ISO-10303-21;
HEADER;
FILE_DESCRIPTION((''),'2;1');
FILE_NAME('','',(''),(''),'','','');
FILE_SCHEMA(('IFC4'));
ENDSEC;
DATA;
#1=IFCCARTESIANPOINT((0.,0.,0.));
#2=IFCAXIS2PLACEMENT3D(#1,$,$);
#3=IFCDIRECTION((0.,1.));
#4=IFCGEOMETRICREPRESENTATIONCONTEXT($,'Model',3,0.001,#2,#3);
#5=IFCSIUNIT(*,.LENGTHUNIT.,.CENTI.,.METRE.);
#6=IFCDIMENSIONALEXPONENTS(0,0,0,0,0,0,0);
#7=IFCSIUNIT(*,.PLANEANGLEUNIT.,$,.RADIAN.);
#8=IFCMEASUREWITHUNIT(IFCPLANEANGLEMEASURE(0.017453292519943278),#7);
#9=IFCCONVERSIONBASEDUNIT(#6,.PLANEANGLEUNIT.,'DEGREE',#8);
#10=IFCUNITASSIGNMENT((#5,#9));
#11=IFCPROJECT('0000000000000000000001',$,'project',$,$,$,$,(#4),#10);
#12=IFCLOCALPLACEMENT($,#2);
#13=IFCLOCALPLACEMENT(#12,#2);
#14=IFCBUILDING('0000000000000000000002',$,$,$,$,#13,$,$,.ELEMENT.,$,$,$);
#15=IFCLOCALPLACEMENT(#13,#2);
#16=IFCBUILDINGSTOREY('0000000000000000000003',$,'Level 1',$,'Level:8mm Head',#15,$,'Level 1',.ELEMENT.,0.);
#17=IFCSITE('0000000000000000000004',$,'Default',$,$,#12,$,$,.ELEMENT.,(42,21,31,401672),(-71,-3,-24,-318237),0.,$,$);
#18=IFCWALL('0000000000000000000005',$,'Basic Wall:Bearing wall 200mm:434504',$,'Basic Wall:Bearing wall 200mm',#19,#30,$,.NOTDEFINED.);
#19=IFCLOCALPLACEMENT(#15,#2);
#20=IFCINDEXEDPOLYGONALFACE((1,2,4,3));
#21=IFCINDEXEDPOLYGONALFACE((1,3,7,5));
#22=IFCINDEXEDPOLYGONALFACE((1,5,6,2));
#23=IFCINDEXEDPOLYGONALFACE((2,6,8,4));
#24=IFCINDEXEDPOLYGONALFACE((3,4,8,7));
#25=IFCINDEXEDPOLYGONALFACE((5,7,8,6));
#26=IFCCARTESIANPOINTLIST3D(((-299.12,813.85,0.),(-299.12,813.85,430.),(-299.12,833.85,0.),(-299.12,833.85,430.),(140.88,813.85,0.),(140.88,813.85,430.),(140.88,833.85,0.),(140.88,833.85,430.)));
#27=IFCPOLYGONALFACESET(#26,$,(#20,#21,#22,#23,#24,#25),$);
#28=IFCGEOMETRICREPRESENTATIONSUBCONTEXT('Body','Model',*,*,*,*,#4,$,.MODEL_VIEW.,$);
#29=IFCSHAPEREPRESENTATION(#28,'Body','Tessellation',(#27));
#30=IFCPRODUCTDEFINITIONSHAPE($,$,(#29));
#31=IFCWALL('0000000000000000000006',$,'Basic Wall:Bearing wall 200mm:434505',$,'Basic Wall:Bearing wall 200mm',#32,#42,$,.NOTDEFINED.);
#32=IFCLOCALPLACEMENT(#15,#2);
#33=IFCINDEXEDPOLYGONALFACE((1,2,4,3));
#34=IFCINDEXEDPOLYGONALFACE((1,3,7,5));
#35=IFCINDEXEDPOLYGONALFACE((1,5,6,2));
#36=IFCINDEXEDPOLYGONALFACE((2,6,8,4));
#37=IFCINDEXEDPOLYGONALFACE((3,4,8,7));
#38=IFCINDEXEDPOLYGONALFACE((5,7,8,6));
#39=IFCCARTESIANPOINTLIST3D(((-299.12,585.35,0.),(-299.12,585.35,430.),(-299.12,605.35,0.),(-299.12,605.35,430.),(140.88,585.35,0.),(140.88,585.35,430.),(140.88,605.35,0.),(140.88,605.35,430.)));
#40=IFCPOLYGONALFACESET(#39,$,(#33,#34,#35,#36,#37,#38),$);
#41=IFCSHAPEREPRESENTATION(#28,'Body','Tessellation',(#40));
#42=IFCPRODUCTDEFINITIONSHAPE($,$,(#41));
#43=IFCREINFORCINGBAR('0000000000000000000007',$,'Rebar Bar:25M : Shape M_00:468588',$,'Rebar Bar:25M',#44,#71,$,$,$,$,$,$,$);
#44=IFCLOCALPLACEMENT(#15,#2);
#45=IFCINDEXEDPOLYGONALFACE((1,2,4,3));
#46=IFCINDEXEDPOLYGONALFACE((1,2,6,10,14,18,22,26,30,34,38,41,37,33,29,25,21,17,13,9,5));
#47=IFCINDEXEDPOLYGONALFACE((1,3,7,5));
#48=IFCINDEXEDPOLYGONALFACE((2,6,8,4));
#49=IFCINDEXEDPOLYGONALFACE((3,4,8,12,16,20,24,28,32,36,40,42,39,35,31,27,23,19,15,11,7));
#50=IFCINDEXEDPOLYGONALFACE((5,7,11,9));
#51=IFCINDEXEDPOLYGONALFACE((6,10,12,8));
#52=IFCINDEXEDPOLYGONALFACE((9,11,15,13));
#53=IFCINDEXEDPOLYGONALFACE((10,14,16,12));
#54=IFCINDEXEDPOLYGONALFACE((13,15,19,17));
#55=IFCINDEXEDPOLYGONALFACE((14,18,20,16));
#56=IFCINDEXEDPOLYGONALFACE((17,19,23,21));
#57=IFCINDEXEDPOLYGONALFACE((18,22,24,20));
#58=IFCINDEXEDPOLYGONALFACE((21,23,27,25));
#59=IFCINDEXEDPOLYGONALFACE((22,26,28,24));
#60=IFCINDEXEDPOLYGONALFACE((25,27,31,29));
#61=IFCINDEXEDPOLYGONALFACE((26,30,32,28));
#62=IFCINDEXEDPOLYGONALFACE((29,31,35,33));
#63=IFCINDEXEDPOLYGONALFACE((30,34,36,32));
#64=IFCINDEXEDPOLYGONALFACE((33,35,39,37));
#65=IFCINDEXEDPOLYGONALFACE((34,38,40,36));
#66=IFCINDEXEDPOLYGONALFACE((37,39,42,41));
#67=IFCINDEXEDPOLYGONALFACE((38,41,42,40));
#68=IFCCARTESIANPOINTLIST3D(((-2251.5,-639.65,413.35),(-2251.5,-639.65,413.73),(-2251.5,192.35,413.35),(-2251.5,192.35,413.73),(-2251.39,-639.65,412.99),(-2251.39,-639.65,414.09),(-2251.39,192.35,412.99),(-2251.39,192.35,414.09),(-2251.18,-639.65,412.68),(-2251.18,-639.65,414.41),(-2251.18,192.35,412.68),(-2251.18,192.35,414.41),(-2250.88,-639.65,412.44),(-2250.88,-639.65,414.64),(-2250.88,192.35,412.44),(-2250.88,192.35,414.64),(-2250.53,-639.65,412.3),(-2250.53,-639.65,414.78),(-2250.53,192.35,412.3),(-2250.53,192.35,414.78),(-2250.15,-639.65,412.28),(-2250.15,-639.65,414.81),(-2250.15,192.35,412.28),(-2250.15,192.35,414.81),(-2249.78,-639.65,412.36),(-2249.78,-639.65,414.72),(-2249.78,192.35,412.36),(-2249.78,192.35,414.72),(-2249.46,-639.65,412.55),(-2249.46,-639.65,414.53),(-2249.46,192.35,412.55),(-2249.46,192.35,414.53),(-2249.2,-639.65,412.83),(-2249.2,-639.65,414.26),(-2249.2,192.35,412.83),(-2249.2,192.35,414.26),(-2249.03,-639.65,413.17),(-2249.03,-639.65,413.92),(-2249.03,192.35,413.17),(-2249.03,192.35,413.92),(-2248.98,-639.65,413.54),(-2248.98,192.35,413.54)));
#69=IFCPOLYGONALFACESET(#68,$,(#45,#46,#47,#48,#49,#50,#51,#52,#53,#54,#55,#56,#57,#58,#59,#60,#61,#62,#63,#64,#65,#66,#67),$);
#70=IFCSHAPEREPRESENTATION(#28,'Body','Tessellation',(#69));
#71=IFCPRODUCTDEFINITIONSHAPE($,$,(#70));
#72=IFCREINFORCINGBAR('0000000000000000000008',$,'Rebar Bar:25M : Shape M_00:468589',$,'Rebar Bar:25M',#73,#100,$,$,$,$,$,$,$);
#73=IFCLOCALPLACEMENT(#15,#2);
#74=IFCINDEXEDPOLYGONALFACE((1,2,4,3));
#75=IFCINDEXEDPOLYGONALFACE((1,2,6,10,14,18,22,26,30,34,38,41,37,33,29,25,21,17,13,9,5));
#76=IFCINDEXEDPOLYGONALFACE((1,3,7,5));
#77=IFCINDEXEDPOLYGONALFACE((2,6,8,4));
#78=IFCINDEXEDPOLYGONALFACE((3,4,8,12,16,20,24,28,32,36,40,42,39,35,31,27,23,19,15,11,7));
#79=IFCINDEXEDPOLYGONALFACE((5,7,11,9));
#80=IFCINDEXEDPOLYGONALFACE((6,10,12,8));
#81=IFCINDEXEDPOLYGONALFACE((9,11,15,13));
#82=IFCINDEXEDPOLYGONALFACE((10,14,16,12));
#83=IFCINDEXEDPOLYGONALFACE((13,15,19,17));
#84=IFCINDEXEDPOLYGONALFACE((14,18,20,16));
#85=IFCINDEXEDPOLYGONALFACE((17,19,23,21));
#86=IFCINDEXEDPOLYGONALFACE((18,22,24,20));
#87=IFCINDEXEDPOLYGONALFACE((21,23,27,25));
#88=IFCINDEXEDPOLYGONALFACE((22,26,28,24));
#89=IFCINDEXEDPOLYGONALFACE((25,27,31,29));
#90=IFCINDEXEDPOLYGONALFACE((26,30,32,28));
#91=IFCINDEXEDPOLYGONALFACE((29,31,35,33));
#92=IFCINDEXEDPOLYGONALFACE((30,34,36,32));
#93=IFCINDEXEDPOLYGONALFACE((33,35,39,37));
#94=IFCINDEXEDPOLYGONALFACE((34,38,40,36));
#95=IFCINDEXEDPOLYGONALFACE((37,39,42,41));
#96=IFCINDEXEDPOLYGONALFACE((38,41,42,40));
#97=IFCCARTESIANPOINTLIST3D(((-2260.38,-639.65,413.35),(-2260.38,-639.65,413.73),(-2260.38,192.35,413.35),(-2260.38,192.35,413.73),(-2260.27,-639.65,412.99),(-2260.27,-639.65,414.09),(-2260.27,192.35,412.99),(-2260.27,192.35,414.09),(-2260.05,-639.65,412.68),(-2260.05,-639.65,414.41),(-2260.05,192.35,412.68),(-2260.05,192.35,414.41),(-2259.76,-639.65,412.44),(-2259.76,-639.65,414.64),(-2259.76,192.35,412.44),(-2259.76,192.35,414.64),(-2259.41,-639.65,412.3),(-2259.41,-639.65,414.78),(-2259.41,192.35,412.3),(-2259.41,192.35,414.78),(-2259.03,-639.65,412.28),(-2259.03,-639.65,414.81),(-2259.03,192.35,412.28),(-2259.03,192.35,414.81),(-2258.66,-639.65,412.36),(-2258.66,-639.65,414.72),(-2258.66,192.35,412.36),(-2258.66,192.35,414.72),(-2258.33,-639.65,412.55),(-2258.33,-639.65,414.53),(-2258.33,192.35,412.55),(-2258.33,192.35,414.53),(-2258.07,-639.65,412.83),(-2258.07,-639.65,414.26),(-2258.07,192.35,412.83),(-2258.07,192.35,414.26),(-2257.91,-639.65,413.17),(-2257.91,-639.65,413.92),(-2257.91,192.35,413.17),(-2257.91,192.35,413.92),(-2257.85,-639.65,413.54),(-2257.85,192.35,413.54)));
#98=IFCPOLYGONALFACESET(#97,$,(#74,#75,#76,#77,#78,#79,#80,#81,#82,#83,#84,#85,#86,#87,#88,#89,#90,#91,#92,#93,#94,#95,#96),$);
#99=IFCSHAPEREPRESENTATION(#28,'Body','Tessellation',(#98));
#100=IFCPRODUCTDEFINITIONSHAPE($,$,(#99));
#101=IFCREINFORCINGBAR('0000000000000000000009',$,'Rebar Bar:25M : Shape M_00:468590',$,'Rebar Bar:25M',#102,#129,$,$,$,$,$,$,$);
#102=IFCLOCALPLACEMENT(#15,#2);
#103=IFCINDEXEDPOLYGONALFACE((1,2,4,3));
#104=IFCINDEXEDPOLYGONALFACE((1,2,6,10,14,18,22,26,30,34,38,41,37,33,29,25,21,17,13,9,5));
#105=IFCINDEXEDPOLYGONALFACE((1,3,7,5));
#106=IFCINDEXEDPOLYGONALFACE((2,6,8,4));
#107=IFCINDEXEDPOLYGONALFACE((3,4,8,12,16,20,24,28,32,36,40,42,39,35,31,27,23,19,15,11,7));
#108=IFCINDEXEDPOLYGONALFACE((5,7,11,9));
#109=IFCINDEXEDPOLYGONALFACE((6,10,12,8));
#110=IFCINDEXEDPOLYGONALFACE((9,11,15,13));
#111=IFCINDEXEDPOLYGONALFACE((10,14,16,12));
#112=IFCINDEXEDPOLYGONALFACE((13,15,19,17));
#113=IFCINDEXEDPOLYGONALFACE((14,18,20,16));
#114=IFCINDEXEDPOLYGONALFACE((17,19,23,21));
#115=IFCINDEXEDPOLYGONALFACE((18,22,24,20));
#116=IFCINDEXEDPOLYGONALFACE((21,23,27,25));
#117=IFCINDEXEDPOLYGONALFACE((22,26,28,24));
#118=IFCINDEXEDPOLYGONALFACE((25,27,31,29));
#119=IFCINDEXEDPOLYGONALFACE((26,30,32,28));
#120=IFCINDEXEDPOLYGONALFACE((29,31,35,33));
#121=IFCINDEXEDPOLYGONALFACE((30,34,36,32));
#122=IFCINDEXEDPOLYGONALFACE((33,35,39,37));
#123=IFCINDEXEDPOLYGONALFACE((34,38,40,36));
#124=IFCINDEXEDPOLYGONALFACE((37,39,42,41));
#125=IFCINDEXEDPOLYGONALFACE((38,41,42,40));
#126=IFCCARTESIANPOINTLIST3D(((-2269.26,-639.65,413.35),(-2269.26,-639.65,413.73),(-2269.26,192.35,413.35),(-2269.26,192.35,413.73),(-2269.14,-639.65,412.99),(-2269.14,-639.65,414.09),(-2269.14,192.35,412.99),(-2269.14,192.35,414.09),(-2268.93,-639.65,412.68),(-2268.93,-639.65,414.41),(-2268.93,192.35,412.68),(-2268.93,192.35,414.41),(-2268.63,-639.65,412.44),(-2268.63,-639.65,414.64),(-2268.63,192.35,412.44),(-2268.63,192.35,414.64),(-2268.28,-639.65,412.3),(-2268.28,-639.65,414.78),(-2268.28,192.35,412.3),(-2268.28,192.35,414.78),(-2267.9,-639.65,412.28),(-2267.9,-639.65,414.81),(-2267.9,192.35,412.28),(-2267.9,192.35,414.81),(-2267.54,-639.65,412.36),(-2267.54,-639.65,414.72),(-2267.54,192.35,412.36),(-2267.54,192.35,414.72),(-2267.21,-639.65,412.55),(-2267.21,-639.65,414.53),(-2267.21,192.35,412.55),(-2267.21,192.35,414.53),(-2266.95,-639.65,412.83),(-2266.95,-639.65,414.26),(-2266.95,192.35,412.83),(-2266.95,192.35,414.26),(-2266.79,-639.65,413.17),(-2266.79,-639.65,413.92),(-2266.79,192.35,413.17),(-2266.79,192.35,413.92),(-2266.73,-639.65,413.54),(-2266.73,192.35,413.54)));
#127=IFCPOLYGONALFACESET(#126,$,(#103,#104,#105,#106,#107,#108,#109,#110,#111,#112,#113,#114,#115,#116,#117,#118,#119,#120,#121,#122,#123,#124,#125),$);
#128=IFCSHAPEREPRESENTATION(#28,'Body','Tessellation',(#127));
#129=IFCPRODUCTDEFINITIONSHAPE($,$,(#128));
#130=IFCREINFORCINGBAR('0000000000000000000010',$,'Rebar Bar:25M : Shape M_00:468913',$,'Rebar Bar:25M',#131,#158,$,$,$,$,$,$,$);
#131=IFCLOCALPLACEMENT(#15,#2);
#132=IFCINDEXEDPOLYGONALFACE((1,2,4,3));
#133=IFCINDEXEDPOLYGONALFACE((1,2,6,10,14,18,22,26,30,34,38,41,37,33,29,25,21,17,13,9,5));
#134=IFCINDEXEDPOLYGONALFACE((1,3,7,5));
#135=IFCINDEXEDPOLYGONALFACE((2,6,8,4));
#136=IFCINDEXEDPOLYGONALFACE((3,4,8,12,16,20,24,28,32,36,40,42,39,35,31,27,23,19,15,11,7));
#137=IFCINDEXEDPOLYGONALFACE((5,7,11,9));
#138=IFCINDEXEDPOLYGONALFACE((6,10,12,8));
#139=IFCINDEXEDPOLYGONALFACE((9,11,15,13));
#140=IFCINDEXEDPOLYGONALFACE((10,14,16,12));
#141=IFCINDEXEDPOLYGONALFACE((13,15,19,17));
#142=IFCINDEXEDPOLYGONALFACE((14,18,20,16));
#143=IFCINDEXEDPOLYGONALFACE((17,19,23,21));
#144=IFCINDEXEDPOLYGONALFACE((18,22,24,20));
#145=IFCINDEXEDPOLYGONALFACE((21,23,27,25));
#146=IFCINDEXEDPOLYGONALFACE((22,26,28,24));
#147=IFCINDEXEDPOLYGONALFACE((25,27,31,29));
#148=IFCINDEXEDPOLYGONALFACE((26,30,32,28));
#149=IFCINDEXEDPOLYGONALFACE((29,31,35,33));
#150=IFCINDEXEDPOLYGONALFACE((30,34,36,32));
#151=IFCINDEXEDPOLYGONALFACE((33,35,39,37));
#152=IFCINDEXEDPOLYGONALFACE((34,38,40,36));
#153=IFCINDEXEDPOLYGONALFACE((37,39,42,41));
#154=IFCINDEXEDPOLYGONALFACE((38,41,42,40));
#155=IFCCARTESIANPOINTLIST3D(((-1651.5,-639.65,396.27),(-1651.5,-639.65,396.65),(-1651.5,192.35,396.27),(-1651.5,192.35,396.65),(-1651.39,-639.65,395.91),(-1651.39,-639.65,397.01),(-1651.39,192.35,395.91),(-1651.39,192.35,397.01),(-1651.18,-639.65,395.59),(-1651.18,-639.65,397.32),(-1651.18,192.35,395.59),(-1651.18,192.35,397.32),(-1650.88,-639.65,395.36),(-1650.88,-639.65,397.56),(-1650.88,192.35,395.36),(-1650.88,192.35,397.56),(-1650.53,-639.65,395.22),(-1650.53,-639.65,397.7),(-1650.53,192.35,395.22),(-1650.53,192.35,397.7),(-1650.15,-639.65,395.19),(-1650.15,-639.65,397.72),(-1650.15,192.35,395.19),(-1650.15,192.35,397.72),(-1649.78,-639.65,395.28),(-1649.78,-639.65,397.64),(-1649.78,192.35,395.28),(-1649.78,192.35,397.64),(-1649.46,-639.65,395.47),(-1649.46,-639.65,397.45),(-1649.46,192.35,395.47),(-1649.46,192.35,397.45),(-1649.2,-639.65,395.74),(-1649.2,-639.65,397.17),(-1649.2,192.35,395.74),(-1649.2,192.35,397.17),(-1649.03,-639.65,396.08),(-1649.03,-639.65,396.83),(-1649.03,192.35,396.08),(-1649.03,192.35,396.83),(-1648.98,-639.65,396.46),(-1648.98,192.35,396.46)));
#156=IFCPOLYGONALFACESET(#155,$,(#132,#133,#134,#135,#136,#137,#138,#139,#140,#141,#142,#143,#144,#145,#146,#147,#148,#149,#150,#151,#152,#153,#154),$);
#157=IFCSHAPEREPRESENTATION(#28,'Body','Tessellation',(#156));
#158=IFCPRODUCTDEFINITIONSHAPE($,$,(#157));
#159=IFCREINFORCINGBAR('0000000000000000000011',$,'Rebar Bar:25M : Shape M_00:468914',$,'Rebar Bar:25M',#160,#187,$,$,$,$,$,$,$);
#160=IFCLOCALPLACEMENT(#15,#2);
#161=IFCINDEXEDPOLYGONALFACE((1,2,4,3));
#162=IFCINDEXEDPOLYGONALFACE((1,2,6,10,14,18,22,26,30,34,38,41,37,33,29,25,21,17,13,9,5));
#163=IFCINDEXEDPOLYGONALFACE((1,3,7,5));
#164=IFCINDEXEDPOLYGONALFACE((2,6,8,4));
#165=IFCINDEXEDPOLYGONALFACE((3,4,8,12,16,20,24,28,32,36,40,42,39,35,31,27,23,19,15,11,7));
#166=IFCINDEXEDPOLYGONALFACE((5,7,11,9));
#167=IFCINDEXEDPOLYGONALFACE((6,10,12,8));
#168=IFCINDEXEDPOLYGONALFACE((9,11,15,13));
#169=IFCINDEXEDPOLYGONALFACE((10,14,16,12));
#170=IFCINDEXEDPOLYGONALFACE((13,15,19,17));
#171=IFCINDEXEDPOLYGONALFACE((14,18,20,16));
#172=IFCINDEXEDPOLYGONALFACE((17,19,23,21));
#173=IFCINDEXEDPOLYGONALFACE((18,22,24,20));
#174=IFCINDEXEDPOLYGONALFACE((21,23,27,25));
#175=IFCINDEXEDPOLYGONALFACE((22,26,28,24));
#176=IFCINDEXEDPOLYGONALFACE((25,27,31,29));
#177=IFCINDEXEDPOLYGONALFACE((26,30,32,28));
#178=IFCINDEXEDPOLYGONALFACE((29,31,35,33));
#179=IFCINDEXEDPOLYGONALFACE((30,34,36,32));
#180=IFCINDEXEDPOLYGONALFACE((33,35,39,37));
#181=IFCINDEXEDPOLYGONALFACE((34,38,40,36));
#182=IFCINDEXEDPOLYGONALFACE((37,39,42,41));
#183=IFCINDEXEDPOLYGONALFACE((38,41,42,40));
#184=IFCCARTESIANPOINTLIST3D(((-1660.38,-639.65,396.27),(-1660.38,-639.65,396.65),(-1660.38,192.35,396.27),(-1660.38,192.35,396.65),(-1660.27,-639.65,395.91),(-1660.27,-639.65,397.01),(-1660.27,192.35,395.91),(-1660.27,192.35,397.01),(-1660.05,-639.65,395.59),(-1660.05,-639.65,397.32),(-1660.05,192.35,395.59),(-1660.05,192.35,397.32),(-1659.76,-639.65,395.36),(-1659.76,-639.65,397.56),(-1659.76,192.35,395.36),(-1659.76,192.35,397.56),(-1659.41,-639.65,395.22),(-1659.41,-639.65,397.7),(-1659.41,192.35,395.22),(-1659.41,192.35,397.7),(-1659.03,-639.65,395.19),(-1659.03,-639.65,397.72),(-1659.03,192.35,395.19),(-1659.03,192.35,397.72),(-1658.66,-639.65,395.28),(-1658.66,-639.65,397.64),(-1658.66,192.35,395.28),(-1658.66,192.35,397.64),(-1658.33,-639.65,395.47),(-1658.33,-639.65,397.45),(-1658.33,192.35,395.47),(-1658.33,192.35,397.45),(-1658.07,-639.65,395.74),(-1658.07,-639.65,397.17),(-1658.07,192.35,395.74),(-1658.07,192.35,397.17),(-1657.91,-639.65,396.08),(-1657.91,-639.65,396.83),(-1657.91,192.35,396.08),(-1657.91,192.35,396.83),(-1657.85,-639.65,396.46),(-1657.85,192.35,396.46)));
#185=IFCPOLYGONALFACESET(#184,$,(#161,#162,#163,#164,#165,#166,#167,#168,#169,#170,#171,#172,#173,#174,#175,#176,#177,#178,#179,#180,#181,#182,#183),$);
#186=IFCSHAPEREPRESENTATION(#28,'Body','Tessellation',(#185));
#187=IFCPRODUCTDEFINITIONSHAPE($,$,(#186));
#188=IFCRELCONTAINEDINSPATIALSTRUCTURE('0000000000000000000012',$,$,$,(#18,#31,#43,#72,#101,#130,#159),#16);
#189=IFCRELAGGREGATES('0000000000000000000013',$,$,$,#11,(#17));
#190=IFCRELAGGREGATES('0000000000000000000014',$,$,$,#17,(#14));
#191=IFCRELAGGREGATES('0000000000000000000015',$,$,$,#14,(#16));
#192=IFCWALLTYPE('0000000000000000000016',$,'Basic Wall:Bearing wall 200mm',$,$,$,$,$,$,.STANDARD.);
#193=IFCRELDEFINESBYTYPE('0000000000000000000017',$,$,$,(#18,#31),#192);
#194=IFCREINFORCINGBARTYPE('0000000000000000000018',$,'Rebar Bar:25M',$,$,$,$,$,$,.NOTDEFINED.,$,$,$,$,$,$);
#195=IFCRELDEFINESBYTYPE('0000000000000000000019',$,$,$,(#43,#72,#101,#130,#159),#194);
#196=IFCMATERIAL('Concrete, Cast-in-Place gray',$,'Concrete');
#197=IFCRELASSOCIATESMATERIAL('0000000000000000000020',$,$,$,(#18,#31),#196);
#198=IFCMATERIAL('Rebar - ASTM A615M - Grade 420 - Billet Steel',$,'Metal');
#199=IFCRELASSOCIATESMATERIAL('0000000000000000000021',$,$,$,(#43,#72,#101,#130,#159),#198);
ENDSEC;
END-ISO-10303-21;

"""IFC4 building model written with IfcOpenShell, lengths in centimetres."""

from ifc_helpers import new_model, entity, si_unit, converted_unit, direction, frame, origin, place, context, subcontext, project, spatial, indexed_curve, outline, extrude, material, type_object, element, save


model = new_model("IFC4")

# Units and contexts
model_context = context("Model", 3, precision=0.001, world=origin(), true_north=direction((0.0, 1.0)))
body_context = subcontext(model_context, "Body", "Model", "MODEL_VIEW")
ifc_project = project(units=[si_unit("LENGTHUNIT", "METRE", prefix="CENTI"), converted_unit("PLANEANGLEUNIT", "DEGREE", entity("IfcPlaneAngleMeasure", 0.017453292519943278), si_unit("PLANEANGLEUNIT", "RADIAN"), dimensions=[0, 0, 0, 0, 0, 0, 0])], contexts=[model_context])

# Site, building, storey
site_placement = place(None, origin())
site = spatial("IfcSite", under=ifc_project, at=site_placement, Name="Default", CompositionType="ELEMENT", RefLatitude=(42, 21, 31, 401672), RefLongitude=(-71, -3, -24, -318237), RefElevation=0.0)
building_placement = place(site_placement, origin())
building = spatial("IfcBuilding", under=site, at=building_placement, CompositionType="ELEMENT")
storey_placement = place(building_placement, origin())
storey = spatial("IfcBuildingStorey", under=building, at=storey_placement, Name="Level 1", ObjectType="Level:8mm Head", LongName="Level 1", CompositionType="ELEMENT", Elevation=0.0)

# Walls
ifc_material_1 = material(Name="Concrete, Cast-in-Place gray", Category="Concrete")
wall_type = type_object("IfcWallType", Name="Basic Wall:Bearing wall 200mm", PredefinedType="STANDARD")
wall_1_placement = place(storey_placement, frame((140.88, 823.85, 0.0), z_axis=(0.0, 0.0, 1.0), x_axis=(-1.0, 0.0, 0.0)))
element("IfcWall", 1, at=wall_1_placement, inside=storey, type_object=wall_type, material=ifc_material_1, Name="Basic Wall:Bearing wall 200mm:434504", ObjectType="Basic Wall:Bearing wall 200mm", PredefinedType="NOTDEFINED", context=body_context, shape_type="SweptSolid", body=[
    extrude(outline(indexed_curve([(440.0, 10.0), (0.0, 10.0), (0.0, -10.0), (440.0, -10.0), (440.0, 10.0)], self_intersect=False)), origin(), (0.0, 0.0, 1.0), 430.0),
])
wall_2_placement = place(storey_placement, frame((-299.12, 595.35, 0.0)))
element("IfcWall", 2, at=wall_2_placement, inside=storey, type_object=wall_type, material=ifc_material_1, Name="Basic Wall:Bearing wall 200mm:434505", ObjectType="Basic Wall:Bearing wall 200mm", PredefinedType="NOTDEFINED", context=body_context, shape_type="SweptSolid", body=[
    extrude(outline(indexed_curve([(440.0, 10.0), (0.0, 10.0), (0.0, -10.0), (440.0, -10.0), (440.0, 10.0)], self_intersect=False)), origin(), (0.0, 0.0, 1.0), 430.0),
])

# Reinforcing bars
ifc_material_2 = material(Name="Rebar - ASTM A615M - Grade 420 - Billet Steel", Category="Metal")
reinforcing_bar_type_1 = type_object("IfcReinforcingBarType", Name="Rebar Bar:25M", PredefinedType="NOTDEFINED")
reinforcing_bar_1_placement = place(storey_placement, origin())
element("IfcReinforcingBar", 3, at=reinforcing_bar_1_placement, inside=storey, type_object=reinforcing_bar_type_1, material=ifc_material_2, Name="Rebar Bar:25M : Shape M_00:468588", ObjectType="Rebar Bar:25M", context=body_context, shape_type="AdvancedSweptSolid", body=[
    entity("IfcSweptDiskSolid", entity("IfcIndexedPolyCurve", entity("IfcCartesianPointList3D", [[-2250.25, -639.65, 413.54], [-2250.25, 192.35, 413.54]]), None, False), 1.27, None, 0.0, 1.0),
])
reinforcing_bar_2_placement = place(storey_placement, origin())
element("IfcReinforcingBar", 4, at=reinforcing_bar_2_placement, inside=storey, type_object=reinforcing_bar_type_1, material=ifc_material_2, Name="Rebar Bar:25M : Shape M_00:468589", ObjectType="Rebar Bar:25M", context=body_context, shape_type="AdvancedSweptSolid", body=[
    entity("IfcSweptDiskSolid", entity("IfcIndexedPolyCurve", entity("IfcCartesianPointList3D", [[-2259.12, -639.65, 413.54], [-2259.12, 192.35, 413.54]]), None, False), 1.27, None, 0.0, 1.0),
])
reinforcing_bar_3_placement = place(storey_placement, origin())
element("IfcReinforcingBar", 5, at=reinforcing_bar_3_placement, inside=storey, type_object=reinforcing_bar_type_1, material=ifc_material_2, Name="Rebar Bar:25M : Shape M_00:468590", ObjectType="Rebar Bar:25M", context=body_context, shape_type="AdvancedSweptSolid", body=[
    entity("IfcSweptDiskSolid", entity("IfcIndexedPolyCurve", entity("IfcCartesianPointList3D", [[-2268.0, -639.65, 413.54], [-2268.0, 192.35, 413.54]]), None, False), 1.27, None, 0.0, 1.0),
])
reinforcing_bar_4_placement = place(storey_placement, origin())
element("IfcReinforcingBar", 6, at=reinforcing_bar_4_placement, inside=storey, type_object=reinforcing_bar_type_1, material=ifc_material_2, Name="Rebar Bar:25M : Shape M_00:468913", ObjectType="Rebar Bar:25M", context=body_context, shape_type="AdvancedSweptSolid", body=[
    entity("IfcSweptDiskSolid", entity("IfcIndexedPolyCurve", entity("IfcCartesianPointList3D", [[-1650.25, -639.65, 396.46], [-1650.25, 192.35, 396.46]]), None, False), 1.27, None, 0.0, 1.0),
])
reinforcing_bar_5_placement = place(storey_placement, origin())
element("IfcReinforcingBar", 7, at=reinforcing_bar_5_placement, inside=storey, type_object=reinforcing_bar_type_1, material=ifc_material_2, Name="Rebar Bar:25M : Shape M_00:468914", ObjectType="Rebar Bar:25M", context=body_context, shape_type="AdvancedSweptSolid", body=[
    entity("IfcSweptDiskSolid", entity("IfcIndexedPolyCurve", entity("IfcCartesianPointList3D", [[-1659.12, -639.65, 396.46], [-1659.12, 192.35, 396.46]]), None, False), 1.27, None, 0.0, 1.0),
])

save(model, "model.ifc")
